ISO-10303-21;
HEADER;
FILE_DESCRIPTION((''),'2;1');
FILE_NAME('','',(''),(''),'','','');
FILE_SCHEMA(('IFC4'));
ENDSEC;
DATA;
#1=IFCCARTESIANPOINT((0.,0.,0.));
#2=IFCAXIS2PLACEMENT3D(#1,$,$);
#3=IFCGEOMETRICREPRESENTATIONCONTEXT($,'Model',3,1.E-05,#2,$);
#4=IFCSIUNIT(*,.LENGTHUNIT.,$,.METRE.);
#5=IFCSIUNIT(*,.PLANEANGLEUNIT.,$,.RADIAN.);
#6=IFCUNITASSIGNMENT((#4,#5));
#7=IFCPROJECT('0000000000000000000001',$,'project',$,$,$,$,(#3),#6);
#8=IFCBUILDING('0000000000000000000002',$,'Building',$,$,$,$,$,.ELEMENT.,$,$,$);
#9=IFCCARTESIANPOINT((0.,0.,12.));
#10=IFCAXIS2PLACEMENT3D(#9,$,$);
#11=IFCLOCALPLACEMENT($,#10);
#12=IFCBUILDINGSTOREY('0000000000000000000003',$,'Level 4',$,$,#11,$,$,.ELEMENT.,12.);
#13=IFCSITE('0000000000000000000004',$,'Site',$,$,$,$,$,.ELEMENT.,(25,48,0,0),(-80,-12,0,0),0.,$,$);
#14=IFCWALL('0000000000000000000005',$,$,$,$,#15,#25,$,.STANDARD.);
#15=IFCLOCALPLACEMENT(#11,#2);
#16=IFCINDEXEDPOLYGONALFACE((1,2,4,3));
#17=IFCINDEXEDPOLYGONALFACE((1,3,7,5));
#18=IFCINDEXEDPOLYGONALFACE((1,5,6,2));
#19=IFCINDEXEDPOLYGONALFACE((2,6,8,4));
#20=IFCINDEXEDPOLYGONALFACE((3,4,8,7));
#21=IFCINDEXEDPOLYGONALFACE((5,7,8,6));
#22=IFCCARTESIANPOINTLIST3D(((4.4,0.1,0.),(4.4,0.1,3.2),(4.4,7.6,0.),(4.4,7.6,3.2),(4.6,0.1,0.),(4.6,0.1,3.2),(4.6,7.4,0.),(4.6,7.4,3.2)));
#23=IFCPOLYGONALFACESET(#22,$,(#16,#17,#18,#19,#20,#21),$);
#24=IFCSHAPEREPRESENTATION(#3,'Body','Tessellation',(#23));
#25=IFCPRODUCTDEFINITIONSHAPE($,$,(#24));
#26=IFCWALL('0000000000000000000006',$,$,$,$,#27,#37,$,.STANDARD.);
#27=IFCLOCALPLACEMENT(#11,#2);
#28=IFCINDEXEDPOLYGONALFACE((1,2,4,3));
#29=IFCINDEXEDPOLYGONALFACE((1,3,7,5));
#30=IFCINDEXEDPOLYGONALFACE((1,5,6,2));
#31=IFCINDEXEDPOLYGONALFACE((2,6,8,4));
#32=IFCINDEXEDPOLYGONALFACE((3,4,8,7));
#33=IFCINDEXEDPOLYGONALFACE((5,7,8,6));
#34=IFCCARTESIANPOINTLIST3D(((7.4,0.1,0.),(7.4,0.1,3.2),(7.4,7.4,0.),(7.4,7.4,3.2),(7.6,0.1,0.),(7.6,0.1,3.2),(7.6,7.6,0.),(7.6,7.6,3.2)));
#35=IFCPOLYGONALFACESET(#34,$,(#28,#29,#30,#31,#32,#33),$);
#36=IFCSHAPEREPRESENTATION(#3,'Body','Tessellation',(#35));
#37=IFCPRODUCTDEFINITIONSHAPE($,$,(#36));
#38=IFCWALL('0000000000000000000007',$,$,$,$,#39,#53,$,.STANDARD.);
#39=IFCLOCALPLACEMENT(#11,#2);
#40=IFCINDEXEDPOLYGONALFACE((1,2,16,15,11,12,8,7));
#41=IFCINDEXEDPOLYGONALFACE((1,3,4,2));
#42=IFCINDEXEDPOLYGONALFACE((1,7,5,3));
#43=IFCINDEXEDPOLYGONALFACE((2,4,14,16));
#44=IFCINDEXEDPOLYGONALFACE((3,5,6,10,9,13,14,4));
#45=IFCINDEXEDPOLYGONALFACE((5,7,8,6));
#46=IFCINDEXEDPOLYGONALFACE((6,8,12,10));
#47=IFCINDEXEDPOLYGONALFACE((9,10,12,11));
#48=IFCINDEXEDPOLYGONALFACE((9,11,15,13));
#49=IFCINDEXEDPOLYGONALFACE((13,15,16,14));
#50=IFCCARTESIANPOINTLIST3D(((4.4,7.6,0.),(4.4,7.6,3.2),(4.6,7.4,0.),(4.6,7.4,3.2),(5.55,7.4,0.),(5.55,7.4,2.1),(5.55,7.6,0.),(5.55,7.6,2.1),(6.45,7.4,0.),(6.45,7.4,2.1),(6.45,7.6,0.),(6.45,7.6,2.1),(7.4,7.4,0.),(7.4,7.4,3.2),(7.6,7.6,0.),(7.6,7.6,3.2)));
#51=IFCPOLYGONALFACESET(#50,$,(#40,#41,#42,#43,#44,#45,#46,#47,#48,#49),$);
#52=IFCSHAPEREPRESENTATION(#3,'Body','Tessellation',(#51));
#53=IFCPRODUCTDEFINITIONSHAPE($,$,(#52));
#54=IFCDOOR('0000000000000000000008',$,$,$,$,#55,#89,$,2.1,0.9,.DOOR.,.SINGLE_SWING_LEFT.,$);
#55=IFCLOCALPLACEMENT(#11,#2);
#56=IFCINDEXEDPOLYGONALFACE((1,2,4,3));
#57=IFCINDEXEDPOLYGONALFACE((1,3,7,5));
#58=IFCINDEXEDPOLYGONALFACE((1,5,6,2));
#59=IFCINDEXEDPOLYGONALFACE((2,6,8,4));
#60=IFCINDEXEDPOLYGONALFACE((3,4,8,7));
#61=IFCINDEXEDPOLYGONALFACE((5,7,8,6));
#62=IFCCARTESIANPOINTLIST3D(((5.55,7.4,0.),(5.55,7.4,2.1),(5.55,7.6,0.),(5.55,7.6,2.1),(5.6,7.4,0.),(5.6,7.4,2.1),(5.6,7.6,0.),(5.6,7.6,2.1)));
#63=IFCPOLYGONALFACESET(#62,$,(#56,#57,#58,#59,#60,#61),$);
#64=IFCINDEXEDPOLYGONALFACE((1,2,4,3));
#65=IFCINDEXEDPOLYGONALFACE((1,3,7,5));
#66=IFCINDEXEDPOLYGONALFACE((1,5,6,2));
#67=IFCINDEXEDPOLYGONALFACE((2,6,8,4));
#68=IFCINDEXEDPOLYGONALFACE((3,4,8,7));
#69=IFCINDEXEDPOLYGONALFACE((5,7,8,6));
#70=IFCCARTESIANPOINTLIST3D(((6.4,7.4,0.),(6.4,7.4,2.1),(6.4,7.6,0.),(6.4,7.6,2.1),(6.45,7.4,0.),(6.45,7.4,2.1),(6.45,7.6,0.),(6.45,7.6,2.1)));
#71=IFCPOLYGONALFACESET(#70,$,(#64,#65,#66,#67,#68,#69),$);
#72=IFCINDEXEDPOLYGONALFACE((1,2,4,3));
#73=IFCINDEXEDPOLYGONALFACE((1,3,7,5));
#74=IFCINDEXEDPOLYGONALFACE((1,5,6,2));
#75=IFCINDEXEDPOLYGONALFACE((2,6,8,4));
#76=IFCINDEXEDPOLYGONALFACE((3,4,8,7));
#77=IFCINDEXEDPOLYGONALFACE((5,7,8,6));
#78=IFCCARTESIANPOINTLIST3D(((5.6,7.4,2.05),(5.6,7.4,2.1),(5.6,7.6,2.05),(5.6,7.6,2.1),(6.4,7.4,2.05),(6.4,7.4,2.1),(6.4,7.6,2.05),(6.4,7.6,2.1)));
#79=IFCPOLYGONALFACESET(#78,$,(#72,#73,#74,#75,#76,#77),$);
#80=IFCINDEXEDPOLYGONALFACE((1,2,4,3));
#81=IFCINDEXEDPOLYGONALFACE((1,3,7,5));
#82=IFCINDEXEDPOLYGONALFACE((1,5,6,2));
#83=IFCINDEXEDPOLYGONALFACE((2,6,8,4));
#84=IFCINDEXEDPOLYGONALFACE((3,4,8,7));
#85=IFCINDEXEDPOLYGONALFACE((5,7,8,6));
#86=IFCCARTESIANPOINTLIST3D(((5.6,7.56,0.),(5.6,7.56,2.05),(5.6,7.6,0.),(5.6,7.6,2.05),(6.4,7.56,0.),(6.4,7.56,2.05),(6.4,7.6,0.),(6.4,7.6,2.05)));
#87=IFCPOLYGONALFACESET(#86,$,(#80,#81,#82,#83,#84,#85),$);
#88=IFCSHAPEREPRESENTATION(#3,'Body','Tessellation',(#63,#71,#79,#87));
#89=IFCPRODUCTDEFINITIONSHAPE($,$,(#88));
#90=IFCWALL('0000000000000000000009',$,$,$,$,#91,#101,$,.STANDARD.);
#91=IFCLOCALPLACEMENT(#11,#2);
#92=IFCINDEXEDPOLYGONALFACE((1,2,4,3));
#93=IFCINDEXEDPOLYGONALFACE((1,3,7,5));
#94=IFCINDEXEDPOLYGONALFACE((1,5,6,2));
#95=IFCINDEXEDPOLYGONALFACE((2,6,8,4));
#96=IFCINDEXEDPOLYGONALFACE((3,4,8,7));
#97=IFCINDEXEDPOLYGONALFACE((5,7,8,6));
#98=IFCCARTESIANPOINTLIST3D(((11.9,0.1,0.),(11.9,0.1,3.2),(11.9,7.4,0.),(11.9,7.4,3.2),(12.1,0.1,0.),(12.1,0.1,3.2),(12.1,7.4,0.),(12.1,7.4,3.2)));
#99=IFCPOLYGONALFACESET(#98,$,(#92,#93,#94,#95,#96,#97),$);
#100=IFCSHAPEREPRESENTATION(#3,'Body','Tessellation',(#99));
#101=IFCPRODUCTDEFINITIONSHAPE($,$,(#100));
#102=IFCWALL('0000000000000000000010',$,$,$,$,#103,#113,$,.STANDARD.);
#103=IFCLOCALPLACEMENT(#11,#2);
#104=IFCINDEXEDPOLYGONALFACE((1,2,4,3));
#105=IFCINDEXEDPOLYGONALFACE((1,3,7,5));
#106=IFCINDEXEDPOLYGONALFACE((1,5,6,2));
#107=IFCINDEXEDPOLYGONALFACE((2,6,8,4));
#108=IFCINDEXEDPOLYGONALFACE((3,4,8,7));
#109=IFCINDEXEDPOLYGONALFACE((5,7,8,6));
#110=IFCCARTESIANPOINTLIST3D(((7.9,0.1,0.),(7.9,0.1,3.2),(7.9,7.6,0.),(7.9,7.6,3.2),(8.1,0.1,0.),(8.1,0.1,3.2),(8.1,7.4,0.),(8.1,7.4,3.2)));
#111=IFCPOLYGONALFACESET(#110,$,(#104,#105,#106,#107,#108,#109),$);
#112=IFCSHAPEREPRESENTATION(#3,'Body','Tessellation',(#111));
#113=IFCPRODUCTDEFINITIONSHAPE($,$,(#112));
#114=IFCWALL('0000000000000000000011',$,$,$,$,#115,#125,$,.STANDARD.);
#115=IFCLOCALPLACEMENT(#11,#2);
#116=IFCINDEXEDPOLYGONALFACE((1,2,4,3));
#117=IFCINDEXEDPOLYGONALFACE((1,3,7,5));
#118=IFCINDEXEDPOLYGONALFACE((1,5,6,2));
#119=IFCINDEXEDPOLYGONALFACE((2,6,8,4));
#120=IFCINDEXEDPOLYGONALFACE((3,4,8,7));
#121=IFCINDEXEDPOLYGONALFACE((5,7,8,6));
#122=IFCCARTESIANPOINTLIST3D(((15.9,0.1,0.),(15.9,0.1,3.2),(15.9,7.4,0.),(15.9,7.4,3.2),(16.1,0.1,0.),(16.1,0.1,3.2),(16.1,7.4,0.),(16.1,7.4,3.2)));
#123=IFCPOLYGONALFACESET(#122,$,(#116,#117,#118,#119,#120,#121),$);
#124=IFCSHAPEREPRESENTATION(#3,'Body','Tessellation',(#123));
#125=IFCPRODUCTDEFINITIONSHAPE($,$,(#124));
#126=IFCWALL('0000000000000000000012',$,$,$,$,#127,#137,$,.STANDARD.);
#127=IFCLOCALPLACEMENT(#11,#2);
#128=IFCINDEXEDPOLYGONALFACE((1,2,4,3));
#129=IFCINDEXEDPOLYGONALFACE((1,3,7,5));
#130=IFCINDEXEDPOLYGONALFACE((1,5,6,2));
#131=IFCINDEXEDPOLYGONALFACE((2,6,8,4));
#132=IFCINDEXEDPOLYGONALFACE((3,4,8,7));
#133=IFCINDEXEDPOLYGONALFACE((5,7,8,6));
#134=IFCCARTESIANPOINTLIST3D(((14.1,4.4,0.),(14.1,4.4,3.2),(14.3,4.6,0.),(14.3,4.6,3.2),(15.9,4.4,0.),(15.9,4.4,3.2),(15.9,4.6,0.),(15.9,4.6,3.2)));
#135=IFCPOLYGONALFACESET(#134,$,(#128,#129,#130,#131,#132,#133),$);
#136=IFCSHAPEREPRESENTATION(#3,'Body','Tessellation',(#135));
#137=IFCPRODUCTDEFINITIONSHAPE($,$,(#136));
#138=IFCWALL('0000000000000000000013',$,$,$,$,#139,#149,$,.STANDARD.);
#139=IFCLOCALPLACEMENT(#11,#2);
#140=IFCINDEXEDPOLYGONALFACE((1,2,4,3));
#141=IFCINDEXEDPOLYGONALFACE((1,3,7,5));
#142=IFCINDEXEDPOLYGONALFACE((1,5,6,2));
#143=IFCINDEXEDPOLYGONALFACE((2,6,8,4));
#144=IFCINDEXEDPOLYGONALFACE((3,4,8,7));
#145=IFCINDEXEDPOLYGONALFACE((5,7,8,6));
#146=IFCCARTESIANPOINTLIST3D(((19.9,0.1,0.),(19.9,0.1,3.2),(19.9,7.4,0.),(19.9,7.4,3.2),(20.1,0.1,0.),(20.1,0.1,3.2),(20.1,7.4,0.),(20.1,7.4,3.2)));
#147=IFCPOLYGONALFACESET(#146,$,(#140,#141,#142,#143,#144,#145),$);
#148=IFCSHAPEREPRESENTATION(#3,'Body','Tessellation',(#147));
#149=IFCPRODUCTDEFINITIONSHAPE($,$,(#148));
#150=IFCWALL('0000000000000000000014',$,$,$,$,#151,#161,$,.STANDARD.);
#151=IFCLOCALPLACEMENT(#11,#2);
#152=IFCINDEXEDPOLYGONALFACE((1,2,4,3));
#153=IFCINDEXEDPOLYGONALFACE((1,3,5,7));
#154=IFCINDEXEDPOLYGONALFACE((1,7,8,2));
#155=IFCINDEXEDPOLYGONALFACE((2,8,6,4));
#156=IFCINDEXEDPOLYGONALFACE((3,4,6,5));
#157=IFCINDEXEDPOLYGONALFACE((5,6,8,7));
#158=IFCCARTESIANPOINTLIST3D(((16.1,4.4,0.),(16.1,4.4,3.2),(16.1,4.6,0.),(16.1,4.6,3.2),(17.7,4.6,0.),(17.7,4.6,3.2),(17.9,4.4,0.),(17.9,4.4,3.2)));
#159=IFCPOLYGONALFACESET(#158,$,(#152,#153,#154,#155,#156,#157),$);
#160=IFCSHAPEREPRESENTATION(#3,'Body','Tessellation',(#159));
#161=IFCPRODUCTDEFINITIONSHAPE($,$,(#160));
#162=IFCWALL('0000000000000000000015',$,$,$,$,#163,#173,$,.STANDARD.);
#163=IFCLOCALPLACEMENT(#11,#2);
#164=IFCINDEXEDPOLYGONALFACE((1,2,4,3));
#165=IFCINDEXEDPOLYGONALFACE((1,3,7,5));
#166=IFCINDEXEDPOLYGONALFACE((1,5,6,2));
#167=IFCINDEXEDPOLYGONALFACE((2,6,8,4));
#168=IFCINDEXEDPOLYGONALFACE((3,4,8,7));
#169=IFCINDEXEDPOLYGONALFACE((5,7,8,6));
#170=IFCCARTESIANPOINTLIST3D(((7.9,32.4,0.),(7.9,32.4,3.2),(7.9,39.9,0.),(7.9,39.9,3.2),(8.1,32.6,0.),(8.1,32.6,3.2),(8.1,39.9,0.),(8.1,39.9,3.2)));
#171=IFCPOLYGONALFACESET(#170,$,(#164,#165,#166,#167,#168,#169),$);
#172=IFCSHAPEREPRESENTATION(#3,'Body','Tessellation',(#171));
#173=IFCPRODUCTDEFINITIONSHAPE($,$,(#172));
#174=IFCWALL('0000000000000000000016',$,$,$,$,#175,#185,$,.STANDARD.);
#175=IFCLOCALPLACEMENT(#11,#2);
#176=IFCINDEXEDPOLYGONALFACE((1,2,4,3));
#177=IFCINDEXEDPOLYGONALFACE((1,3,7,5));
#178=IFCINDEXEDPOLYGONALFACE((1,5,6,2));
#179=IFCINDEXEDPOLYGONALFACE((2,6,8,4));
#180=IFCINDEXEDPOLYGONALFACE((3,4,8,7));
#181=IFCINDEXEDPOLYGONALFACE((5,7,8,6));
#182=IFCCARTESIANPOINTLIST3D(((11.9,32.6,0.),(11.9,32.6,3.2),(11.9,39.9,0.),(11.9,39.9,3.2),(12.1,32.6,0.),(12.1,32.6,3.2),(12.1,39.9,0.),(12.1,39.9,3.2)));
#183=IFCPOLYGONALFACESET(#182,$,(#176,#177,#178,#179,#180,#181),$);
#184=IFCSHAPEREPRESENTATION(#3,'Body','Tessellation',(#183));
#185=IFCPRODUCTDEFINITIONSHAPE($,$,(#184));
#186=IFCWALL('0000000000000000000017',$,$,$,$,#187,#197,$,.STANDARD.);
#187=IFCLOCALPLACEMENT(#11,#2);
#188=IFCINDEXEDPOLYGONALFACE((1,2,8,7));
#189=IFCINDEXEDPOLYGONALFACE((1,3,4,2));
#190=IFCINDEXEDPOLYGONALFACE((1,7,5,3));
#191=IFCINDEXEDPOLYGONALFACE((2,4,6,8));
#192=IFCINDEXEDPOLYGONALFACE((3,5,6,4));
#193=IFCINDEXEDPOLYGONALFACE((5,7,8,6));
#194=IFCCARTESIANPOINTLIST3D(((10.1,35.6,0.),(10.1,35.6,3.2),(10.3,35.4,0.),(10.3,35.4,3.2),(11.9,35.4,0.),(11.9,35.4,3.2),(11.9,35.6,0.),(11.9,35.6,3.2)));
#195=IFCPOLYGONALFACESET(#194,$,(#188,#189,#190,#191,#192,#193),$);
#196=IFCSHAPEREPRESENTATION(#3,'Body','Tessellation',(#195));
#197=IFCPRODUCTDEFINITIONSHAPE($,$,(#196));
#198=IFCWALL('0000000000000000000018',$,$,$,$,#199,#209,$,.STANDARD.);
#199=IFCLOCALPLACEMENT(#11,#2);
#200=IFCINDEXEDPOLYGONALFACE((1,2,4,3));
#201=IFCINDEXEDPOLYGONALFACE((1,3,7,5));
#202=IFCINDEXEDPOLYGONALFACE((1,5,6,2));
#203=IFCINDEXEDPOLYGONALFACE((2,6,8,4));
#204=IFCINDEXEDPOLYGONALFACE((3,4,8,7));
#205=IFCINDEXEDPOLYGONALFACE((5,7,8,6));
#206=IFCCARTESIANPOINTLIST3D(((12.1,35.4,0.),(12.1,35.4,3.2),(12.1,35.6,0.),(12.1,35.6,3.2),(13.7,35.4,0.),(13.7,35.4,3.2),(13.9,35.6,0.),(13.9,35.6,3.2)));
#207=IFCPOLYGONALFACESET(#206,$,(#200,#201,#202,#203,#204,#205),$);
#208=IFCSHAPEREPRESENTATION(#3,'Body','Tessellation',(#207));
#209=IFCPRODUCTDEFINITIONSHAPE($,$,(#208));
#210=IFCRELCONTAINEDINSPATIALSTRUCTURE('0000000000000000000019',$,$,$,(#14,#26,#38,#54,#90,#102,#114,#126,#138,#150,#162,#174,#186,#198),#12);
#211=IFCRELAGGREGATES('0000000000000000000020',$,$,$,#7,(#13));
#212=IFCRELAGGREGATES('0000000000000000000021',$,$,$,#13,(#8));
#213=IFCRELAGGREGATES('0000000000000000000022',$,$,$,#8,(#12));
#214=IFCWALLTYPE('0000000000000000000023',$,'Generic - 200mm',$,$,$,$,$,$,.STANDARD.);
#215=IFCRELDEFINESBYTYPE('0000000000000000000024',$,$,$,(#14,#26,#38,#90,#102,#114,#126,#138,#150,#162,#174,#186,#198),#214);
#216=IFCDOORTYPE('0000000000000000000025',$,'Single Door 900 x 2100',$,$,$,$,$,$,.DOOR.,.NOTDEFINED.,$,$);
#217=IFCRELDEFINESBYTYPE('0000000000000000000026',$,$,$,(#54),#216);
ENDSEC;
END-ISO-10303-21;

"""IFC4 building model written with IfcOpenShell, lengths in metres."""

from ifc_helpers import new_model, si_unit, frame, frame_2d, origin, origin_with_axes, origin_2d, place, context, project, spatial, polyline, rectangle, outline, extrude, type_object, element, fill, save


model = new_model("IFC4")

# Units and contexts
model_context = context("Model", 3, precision=1e-05, world=origin())
ifc_project = project(units=[si_unit("LENGTHUNIT", "METRE"), si_unit("PLANEANGLEUNIT", "RADIAN")], contexts=[model_context])

# Site, building, storey
site = spatial("IfcSite", under=ifc_project, Name="Site", CompositionType="ELEMENT", RefLatitude=(25, 48, 0, 0), RefLongitude=(-80, -12, 0, 0), RefElevation=0.0)
building = spatial("IfcBuilding", under=site, Name="Building", CompositionType="ELEMENT")
storey_placement = place(None, frame((0.0, 0.0, 12.0)))
storey = spatial("IfcBuildingStorey", under=building, at=storey_placement, Name="Level 4", CompositionType="ELEMENT", Elevation=12.0)

# Shared definitions
wall_type = type_object("IfcWallType", Name="Generic - 200mm", PredefinedType="STANDARD")

# Walls
wall_1_placement = place(None, frame((4.5, 7.5, 12.0), z_axis=(0.0, 0.0, 1.0), x_axis=(0.0, -1.0, 0.0)))
element("IfcWall", 1, at=wall_1_placement, inside=storey, type_object=wall_type, PredefinedType="STANDARD", context=model_context, shape_type="SweptSolid", body=[
    extrude(outline(polyline([(-0.1, -0.1), (7.4, -0.1), (7.4, 0.1), (0.1, 0.1), (-0.1, -0.1)])), origin(), (0.0, 0.0, 1.0), 3.2),
])
wall_2_placement = place(None, frame((7.5, 7.5, 12.0), z_axis=(0.0, 0.0, 1.0), x_axis=(0.0, -1.0, 0.0)))
element("IfcWall", 2, at=wall_2_placement, inside=storey, type_object=wall_type, PredefinedType="STANDARD", context=model_context, shape_type="SweptSolid", body=[
    extrude(outline(polyline([(0.1, -0.1), (7.4, -0.1), (7.4, 0.1), (-0.1, 0.1), (0.1, -0.1)])), origin(), (0.0, 0.0, 1.0), 3.2),
])

# Wall, opening, door
wall_3_placement = place(None, frame((4.5, 7.5, 12.0), z_axis=(0.0, 0.0, 1.0), x_axis=(1.0, 0.0, 0.0)))
wall_3 = element("IfcWall", 3, at=wall_3_placement, inside=storey, type_object=wall_type, PredefinedType="STANDARD", context=model_context, shape_type="SweptSolid", body=[
    extrude(outline(polyline([(0.1, -0.1), (2.9, -0.1), (3.1, 0.1), (-0.1, 0.1), (0.1, -0.1)])), origin(), (0.0, 0.0, 1.0), 3.2),
])
opening_1_placement = place(wall_3_placement, frame((1.5, 0.0, 0.0), z_axis=(0.0, 0.0, 1.0), x_axis=(1.0, 0.0, 0.0)))
opening_1 = element("IfcOpeningElement", 4, at=opening_1_placement, cuts=wall_3, PredefinedType="OPENING", context=model_context, shape_type="SweptSolid", body=[
    extrude(rectangle(XDim=0.9, YDim=0.202, at=origin_2d()), origin(), (0.0, 0.0, 1.0), 2.1),
])
door_type = type_object("IfcDoorType", Name="Single Door 900 x 2100", OperationType="NOTDEFINED", PredefinedType="DOOR")
door_placement = place(opening_1_placement, origin_with_axes())
door = element("IfcDoor", 5, at=door_placement, inside=storey, type_object=door_type, OperationType="SINGLE_SWING_LEFT", OverallHeight=2.1, OverallWidth=0.9, PredefinedType="DOOR", context=model_context, shape_type="SweptSolid", body=[
    extrude(rectangle(XDim=0.05, YDim=0.2, at=frame_2d((-0.425, 0.0))), origin(), (0.0, 0.0, 1.0), 2.1),
    extrude(rectangle(XDim=0.05, YDim=0.2, at=frame_2d((0.425, 0.0))), origin(), (0.0, 0.0, 1.0), 2.1),
    extrude(rectangle(XDim=0.8, YDim=0.2, at=origin_2d()), frame((0.0, 0.0, 2.05)), (0.0, 0.0, 1.0), 0.05),
    extrude(rectangle(XDim=0.8, YDim=0.04, at=frame_2d((0.0, 0.08))), origin(), (0.0, 0.0, 1.0), 2.05),
])
fill(opening_1, door)

# Walls
wall_4_placement = place(None, frame((12.0, 7.5, 12.0), z_axis=(0.0, 0.0, 1.0), x_axis=(0.0, -1.0, 0.0)))
element("IfcWall", 6, at=wall_4_placement, inside=storey, type_object=wall_type, PredefinedType="STANDARD", context=model_context, shape_type="SweptSolid", body=[
    extrude(outline(polyline([(0.1, -0.1), (7.4, -0.1), (7.4, 0.1), (0.1, 0.1), (0.1, -0.1)])), origin(), (0.0, 0.0, 1.0), 3.2),
])
wall_5_placement = place(None, frame((8.0, 7.5, 12.0), z_axis=(0.0, 0.0, 1.0), x_axis=(0.0, -1.0, 0.0)))
element("IfcWall", 7, at=wall_5_placement, inside=storey, type_object=wall_type, PredefinedType="STANDARD", context=model_context, shape_type="SweptSolid", body=[
    extrude(outline(polyline([(-0.1, -0.1), (7.4, -0.1), (7.4, 0.1), (0.1, 0.1), (-0.1, -0.1)])), origin(), (0.0, 0.0, 1.0), 3.2),
])
wall_6_placement = place(None, frame((16.0, 7.5, 12.0), z_axis=(0.0, 0.0, 1.0), x_axis=(0.0, -1.0, 0.0)))
element("IfcWall", 8, at=wall_6_placement, inside=storey, type_object=wall_type, PredefinedType="STANDARD", context=model_context, shape_type="SweptSolid", body=[
    extrude(outline(polyline([(0.1, -0.1), (7.4, -0.1), (7.4, 0.1), (0.1, 0.1), (0.1, -0.1)])), origin(), (0.0, 0.0, 1.0), 3.2),
])
wall_7_placement = place(None, frame((14.2, 4.5, 12.0), z_axis=(0.0, 0.0, 1.0), x_axis=(1.0, 0.0, 0.0)))
element("IfcWall", 9, at=wall_7_placement, inside=storey, type_object=wall_type, PredefinedType="STANDARD", context=model_context, shape_type="SweptSolid", body=[
    extrude(outline(polyline([(-0.1, -0.1), (1.7, -0.1), (1.7, 0.1), (0.1, 0.1), (-0.1, -0.1)])), origin(), (0.0, 0.0, 1.0), 3.2),
])
wall_8_placement = place(None, frame((20.0, 7.5, 12.0), z_axis=(0.0, 0.0, 1.0), x_axis=(0.0, -1.0, 0.0)))
element("IfcWall", 10, at=wall_8_placement, inside=storey, type_object=wall_type, PredefinedType="STANDARD", context=model_context, shape_type="SweptSolid", body=[
    extrude(outline(polyline([(0.1, -0.1), (7.4, -0.1), (7.4, 0.1), (0.1, 0.1), (0.1, -0.1)])), origin(), (0.0, 0.0, 1.0), 3.2),
])
wall_9_placement = place(None, frame((17.8, 4.5, 12.0), z_axis=(0.0, 0.0, 1.0), x_axis=(-1.0, 0.0, 0.0)))
element("IfcWall", 11, at=wall_9_placement, inside=storey, type_object=wall_type, PredefinedType="STANDARD", context=model_context, shape_type="SweptSolid", body=[
    extrude(outline(polyline([(0.1, -0.1), (1.7, -0.1), (1.7, 0.1), (-0.1, 0.1), (0.1, -0.1)])), origin(), (0.0, 0.0, 1.0), 3.2),
])
wall_10_placement = place(None, frame((8.0, 32.5, 12.0), z_axis=(0.0, 0.0, 1.0), x_axis=(0.0, 1.0, 0.0)))
element("IfcWall", 12, at=wall_10_placement, inside=storey, type_object=wall_type, PredefinedType="STANDARD", context=model_context, shape_type="SweptSolid", body=[
    extrude(outline(polyline([(0.1, -0.1), (7.4, -0.1), (7.4, 0.1), (-0.1, 0.1), (0.1, -0.1)])), origin(), (0.0, 0.0, 1.0), 3.2),
])
wall_11_placement = place(None, frame((12.0, 32.5, 12.0), z_axis=(0.0, 0.0, 1.0), x_axis=(0.0, 1.0, 0.0)))
element("IfcWall", 13, at=wall_11_placement, inside=storey, type_object=wall_type, PredefinedType="STANDARD", context=model_context, shape_type="SweptSolid", body=[
    extrude(outline(polyline([(0.1, -0.1), (7.4, -0.1), (7.4, 0.1), (0.1, 0.1), (0.1, -0.1)])), origin(), (0.0, 0.0, 1.0), 3.2),
])
wall_12_placement = place(None, frame((10.2, 35.5, 12.0), z_axis=(0.0, 0.0, 1.0), x_axis=(1.0, 0.0, 0.0)))
element("IfcWall", 14, at=wall_12_placement, inside=storey, type_object=wall_type, PredefinedType="STANDARD", context=model_context, shape_type="SweptSolid", body=[
    extrude(outline(polyline([(0.1, -0.1), (1.7, -0.1), (1.7, 0.1), (-0.1, 0.1), (0.1, -0.1)])), origin(), (0.0, 0.0, 1.0), 3.2),
])
wall_13_placement = place(None, frame((13.8, 35.5, 12.0), z_axis=(0.0, 0.0, 1.0), x_axis=(-1.0, 0.0, 0.0)))
element("IfcWall", 15, at=wall_13_placement, inside=storey, type_object=wall_type, PredefinedType="STANDARD", context=model_context, shape_type="SweptSolid", body=[
    extrude(outline(polyline([(-0.1, -0.1), (1.7, -0.1), (1.7, 0.1), (0.1, 0.1), (-0.1, -0.1)])), origin(), (0.0, 0.0, 1.0), 3.2),
])

save(model, "model.ifc")
